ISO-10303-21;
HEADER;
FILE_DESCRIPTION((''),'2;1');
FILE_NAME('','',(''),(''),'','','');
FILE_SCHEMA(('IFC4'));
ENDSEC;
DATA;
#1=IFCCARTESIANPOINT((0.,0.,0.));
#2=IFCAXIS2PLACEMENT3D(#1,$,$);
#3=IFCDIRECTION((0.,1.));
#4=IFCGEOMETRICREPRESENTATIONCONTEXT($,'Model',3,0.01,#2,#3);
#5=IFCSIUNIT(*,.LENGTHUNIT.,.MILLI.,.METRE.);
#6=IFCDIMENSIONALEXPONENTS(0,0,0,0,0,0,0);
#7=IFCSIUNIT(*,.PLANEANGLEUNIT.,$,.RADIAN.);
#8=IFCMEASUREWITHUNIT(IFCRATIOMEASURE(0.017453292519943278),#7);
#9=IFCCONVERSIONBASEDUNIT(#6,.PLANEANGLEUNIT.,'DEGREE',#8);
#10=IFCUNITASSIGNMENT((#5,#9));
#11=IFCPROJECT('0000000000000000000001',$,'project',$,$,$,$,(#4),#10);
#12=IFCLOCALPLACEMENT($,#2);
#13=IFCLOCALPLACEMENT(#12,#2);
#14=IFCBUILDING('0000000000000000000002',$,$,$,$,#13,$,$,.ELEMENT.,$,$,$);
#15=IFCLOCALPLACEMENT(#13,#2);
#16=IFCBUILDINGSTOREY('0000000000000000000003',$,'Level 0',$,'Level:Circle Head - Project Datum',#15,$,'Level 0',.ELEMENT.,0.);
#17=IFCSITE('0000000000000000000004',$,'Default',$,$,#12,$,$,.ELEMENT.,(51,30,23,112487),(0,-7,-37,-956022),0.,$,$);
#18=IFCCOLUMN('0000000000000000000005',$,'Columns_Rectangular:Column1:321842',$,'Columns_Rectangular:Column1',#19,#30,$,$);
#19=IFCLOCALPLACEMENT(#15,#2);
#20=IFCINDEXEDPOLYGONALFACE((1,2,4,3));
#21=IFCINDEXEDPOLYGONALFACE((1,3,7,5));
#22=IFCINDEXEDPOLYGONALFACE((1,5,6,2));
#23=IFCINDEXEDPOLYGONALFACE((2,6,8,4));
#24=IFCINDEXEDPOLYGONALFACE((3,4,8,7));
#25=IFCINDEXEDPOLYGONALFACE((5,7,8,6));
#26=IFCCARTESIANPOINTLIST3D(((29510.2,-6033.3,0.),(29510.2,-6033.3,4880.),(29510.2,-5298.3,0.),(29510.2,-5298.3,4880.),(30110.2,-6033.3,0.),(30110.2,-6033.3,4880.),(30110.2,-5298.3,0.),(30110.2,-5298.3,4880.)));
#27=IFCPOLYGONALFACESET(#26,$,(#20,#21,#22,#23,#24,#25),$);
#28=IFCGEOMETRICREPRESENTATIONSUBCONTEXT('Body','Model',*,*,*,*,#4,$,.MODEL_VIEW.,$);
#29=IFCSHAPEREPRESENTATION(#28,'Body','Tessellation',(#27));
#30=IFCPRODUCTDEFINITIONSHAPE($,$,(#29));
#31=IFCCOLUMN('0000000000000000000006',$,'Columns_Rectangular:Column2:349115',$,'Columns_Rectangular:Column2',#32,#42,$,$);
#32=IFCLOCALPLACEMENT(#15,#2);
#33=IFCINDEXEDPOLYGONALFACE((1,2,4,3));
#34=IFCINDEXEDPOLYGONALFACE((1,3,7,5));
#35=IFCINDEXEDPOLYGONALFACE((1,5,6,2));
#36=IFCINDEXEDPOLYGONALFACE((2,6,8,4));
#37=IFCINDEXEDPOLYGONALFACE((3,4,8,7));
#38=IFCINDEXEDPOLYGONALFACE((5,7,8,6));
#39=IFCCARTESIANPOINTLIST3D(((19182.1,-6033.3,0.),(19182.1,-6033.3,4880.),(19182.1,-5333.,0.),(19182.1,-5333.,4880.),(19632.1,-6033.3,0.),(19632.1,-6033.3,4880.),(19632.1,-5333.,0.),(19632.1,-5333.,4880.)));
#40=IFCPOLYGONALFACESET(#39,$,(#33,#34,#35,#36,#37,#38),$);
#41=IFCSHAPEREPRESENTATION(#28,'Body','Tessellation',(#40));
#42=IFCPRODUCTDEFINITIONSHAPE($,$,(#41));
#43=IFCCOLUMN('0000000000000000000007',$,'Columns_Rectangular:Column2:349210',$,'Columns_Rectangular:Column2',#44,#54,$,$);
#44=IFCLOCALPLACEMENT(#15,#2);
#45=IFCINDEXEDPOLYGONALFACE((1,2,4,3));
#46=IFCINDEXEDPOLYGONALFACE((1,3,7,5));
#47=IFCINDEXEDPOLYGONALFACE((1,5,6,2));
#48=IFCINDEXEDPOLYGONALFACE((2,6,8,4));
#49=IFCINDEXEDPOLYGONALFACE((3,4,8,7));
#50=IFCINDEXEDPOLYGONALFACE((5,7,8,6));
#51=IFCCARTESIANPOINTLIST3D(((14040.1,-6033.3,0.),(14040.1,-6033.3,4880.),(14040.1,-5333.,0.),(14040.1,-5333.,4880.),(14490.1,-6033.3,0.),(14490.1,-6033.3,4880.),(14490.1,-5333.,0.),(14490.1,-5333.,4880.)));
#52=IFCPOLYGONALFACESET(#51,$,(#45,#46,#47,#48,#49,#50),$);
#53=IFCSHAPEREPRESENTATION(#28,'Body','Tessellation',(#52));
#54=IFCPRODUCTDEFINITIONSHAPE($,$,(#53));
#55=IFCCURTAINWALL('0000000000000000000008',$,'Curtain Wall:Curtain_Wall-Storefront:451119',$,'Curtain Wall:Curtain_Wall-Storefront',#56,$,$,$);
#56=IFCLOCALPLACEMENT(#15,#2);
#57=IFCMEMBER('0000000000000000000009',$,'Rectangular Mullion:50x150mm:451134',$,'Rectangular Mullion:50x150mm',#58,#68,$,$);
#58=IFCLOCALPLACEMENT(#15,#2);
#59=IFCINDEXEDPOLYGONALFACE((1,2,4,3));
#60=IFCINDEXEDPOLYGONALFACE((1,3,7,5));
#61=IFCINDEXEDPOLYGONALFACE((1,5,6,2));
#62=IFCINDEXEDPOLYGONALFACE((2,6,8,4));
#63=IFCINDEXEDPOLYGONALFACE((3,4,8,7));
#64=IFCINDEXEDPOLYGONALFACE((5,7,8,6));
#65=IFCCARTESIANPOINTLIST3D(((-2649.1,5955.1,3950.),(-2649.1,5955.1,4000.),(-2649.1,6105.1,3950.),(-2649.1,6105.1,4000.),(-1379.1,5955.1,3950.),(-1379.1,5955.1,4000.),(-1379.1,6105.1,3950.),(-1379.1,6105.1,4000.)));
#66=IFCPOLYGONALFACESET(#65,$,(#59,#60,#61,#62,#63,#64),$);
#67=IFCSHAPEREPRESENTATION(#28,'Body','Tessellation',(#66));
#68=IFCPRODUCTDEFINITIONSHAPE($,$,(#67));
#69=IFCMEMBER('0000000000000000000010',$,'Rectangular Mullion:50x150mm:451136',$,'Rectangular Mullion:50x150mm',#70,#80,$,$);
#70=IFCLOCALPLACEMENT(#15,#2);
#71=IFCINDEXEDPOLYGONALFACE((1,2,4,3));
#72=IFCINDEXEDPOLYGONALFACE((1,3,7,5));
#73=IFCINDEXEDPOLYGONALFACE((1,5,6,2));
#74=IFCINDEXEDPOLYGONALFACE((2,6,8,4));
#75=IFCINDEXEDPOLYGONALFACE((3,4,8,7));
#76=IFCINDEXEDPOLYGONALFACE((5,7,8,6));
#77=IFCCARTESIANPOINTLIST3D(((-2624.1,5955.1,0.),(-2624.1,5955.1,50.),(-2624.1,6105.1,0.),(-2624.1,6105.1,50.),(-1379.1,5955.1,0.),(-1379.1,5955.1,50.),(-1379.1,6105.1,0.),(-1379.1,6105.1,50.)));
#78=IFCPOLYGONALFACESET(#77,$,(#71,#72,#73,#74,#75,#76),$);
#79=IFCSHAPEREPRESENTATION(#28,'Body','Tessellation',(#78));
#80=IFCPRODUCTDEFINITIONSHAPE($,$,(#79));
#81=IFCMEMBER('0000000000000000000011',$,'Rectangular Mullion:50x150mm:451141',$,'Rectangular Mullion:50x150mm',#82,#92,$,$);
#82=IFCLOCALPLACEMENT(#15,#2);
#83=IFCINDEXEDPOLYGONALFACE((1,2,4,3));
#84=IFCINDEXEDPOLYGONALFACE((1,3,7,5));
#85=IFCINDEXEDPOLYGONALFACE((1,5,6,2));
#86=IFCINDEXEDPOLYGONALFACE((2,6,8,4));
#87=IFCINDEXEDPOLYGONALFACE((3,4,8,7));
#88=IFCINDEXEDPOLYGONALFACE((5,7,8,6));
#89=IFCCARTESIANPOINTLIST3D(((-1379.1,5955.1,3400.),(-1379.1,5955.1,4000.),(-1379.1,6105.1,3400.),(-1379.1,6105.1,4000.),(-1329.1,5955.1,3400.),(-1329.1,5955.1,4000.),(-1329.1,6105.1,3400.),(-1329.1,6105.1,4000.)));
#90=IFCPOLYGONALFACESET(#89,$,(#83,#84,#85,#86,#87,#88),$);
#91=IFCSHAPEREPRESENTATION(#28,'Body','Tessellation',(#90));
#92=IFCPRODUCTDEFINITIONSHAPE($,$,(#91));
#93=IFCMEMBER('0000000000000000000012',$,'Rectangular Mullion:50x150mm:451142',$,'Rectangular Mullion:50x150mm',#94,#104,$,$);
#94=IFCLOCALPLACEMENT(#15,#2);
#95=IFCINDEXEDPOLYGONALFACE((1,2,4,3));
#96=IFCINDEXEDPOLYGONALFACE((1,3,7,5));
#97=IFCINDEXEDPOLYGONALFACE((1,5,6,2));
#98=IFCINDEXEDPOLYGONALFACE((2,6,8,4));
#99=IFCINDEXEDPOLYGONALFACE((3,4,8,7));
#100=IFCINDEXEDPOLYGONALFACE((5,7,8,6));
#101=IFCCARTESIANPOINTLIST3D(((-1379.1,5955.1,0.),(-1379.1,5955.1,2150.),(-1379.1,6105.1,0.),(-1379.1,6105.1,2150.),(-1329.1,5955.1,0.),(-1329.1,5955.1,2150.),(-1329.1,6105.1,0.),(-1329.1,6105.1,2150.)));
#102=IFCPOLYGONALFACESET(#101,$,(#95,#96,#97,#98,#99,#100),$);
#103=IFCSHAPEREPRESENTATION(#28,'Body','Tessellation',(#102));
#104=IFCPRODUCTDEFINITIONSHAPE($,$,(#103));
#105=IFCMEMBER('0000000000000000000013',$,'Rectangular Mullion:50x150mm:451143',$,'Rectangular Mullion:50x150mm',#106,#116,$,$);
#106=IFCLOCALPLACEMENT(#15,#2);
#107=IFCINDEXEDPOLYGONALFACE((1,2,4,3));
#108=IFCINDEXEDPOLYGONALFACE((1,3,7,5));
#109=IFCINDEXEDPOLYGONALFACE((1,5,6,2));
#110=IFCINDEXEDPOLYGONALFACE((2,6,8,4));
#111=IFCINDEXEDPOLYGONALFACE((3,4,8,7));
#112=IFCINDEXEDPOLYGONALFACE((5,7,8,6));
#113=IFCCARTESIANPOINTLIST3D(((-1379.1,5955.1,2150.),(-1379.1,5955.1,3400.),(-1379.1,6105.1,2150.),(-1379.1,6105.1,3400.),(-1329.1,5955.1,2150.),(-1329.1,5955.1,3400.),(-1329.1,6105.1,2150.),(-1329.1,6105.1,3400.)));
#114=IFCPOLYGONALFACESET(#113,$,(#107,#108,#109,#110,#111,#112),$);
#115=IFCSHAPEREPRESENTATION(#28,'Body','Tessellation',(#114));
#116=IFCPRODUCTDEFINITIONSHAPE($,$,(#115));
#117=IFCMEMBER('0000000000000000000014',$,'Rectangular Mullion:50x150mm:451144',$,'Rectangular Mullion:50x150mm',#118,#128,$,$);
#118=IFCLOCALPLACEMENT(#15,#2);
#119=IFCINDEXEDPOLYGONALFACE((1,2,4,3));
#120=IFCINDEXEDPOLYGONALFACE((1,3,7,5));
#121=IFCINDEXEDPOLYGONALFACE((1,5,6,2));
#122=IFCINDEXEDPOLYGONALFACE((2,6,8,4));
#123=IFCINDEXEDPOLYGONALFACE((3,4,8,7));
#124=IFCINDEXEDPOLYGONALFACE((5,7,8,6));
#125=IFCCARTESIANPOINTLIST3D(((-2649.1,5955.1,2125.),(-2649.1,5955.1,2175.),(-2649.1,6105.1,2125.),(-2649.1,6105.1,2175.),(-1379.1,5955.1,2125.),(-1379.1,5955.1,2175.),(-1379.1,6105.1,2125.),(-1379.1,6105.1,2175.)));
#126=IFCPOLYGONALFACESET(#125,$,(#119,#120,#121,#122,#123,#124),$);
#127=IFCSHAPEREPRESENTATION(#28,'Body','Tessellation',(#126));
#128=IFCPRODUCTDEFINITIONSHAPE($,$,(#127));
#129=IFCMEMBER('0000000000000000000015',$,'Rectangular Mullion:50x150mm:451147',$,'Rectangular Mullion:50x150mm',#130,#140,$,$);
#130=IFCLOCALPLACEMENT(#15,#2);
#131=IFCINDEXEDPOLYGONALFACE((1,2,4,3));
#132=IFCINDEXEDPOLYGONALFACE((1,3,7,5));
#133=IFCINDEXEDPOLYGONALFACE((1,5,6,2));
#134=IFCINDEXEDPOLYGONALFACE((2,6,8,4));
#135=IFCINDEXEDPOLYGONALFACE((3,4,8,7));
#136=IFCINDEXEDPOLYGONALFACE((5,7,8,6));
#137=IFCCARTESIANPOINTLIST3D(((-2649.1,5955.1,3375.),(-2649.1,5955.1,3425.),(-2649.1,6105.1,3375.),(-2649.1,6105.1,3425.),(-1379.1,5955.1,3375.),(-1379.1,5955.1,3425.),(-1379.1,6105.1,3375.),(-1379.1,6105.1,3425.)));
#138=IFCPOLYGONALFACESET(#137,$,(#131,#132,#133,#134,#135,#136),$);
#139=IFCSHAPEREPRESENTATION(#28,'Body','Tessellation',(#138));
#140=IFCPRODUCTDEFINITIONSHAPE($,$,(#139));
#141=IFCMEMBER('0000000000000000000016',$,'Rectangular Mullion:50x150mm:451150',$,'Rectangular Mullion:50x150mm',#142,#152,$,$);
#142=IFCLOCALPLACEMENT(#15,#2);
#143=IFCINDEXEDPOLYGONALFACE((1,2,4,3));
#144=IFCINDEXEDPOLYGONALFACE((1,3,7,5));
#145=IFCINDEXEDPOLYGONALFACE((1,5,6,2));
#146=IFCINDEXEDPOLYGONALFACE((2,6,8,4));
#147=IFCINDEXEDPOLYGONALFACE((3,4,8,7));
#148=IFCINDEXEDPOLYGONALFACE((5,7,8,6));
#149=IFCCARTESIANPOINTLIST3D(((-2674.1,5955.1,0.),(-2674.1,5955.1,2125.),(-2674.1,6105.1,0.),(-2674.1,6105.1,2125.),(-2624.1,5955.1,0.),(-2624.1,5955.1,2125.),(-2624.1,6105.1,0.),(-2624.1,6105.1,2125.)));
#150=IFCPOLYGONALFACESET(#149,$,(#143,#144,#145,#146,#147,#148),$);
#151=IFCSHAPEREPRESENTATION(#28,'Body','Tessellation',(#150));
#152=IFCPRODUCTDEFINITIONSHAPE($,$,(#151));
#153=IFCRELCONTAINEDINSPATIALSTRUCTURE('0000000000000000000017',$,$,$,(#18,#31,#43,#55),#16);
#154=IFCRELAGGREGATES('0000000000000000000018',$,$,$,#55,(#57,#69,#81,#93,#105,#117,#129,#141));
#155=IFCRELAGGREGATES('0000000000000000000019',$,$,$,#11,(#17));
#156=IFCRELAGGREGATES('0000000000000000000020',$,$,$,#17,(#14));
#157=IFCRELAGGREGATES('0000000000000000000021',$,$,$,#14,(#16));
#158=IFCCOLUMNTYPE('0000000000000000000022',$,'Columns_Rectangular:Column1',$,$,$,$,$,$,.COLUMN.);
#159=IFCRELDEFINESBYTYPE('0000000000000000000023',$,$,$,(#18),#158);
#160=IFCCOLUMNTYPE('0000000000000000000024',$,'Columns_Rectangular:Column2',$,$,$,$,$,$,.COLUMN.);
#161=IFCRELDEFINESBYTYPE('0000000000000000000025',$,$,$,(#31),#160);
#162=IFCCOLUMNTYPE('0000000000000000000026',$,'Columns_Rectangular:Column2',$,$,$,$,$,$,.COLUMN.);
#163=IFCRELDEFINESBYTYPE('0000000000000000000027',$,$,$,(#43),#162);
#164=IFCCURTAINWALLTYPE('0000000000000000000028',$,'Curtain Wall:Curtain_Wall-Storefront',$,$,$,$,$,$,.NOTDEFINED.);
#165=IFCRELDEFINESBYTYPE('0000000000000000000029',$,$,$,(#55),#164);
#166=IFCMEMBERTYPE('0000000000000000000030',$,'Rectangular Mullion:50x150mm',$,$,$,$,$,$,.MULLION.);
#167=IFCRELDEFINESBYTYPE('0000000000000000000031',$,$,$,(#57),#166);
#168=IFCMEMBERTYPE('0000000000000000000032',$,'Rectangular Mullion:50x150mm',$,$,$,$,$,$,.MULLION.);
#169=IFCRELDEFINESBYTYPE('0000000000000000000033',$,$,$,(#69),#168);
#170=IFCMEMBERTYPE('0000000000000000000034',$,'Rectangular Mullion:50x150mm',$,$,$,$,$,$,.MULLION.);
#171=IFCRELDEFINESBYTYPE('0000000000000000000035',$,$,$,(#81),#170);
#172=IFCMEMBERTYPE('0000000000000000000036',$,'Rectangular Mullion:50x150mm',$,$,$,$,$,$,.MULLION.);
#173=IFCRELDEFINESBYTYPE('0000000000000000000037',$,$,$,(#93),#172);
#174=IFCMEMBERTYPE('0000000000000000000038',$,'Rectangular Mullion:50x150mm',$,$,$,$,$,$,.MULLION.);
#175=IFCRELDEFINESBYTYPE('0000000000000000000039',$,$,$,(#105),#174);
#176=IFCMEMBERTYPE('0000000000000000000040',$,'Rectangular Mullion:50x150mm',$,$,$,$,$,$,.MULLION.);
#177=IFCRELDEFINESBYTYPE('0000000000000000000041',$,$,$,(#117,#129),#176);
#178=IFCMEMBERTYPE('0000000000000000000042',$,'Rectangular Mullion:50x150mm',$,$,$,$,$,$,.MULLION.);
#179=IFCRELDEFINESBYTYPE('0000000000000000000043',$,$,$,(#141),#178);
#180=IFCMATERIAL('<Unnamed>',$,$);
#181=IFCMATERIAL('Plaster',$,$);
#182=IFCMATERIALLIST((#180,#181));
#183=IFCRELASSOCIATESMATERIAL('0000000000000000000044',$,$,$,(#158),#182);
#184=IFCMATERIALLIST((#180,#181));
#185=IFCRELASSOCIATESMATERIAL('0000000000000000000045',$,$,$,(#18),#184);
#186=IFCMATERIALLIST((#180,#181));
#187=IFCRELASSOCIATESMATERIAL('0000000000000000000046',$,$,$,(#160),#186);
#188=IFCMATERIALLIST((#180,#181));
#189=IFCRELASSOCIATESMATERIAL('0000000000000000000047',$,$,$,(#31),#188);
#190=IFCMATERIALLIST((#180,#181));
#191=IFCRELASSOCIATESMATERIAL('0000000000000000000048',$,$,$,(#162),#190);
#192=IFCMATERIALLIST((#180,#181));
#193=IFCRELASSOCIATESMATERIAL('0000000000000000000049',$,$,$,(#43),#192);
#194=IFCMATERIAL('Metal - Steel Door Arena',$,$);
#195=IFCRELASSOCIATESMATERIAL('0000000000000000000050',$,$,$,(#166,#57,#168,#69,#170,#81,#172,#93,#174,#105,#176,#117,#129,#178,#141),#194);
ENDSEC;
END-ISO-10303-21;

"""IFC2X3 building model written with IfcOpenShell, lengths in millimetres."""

from ifc_helpers import new_model, entity, si_unit, converted_unit, direction, frame, frame_2d, origin, origin_2d_with_axis, place, context, subcontext, project, spatial, rectangle, extrude, source, transform, mapped, material, material_list, type_object, type_shapes, element, aggregate, save


model = new_model("IFC2X3")

# Units and contexts
model_context = context("Model", 3, precision=0.01, world=origin(), true_north=direction((0.0, 1.0)))
body_context = subcontext(model_context, "Body", "Model", "MODEL_VIEW")
ifc_project = project(units=[si_unit("LENGTHUNIT", "METRE", prefix="MILLI"), converted_unit("PLANEANGLEUNIT", "DEGREE", entity("IfcRatioMeasure", 0.017453292519943278), si_unit("PLANEANGLEUNIT", "RADIAN"), dimensions=[0, 0, 0, 0, 0, 0, 0])], contexts=[model_context])

# Site, building, storey
site_placement = place(None, origin())
site = spatial("IfcSite", under=ifc_project, at=site_placement, Name="Default", CompositionType="ELEMENT", RefLatitude=(51, 30, 23, 112487), RefLongitude=(0, -7, -37, -956022), RefElevation=0.0)
building_placement = place(site_placement, origin())
building = spatial("IfcBuilding", under=site, at=building_placement, CompositionType="ELEMENT")
storey_placement = place(building_placement, origin())
storey = spatial("IfcBuildingStorey", under=building, at=storey_placement, Name="Level 0", ObjectType="Level:Circle Head - Project Datum", LongName="Level 0", CompositionType="ELEMENT", Elevation=0.0)

# Columns
ifc_material_1 = material(Name="<Unnamed>")
ifc_material_2 = material(Name="Plaster")
ifc_material_list_1 = material_list([ifc_material_1, ifc_material_2])
ifc_material_list_2 = material_list([ifc_material_1, ifc_material_2])
column_type_1 = type_object("IfcColumnType", Name="Columns_Rectangular:Column1", PredefinedType="COLUMN", material=ifc_material_list_2)
shared_shape_1 = source(origin(), body_context, "Body", "SweptSolid", [
    extrude(rectangle(XDim=735.0, YDim=600.0, at=frame_2d((0.0, 0.0), x_axis=(1.0, 0.0))), frame((29810.2, -5665.8, 0.0), z_axis=(0.0, 0.0, 1.0), x_axis=(0.0, -1.0, 0.0)), (0.0, 0.0, 1.0), 4880.0),
])
type_shapes(column_type_1, [shared_shape_1])
column_1_placement = place(storey_placement, origin())
element("IfcColumn", 1, at=column_1_placement, inside=storey, type_object=column_type_1, material=ifc_material_list_1, Name="Columns_Rectangular:Column1:321842", ObjectType="Columns_Rectangular:Column1", context=body_context, shape_type="MappedRepresentation", body=[
    mapped(shared_shape_1, transform((0.0, 0.0, 0.0), scale=1.0)),
])
ifc_material_list_3 = material_list([ifc_material_1, ifc_material_2])
ifc_material_list_4 = material_list([ifc_material_1, ifc_material_2])
column_type_2 = type_object("IfcColumnType", Name="Columns_Rectangular:Column2", PredefinedType="COLUMN", material=ifc_material_list_4)
shared_shape_2 = source(origin(), body_context, "Body", "SweptSolid", [
    extrude(rectangle(XDim=700.3, YDim=450.0, at=frame_2d((0.0, 0.0), x_axis=(1.0, 0.0))), frame((19407.1, -5683.1, 0.0), z_axis=(0.0, 0.0, 1.0), x_axis=(0.0, -1.0, 0.0)), (0.0, 0.0, 1.0), 4880.0),
])
type_shapes(column_type_2, [shared_shape_2])
column_2_placement = place(storey_placement, origin())
element("IfcColumn", 2, at=column_2_placement, inside=storey, type_object=column_type_2, material=ifc_material_list_3, Name="Columns_Rectangular:Column2:349115", ObjectType="Columns_Rectangular:Column2", context=body_context, shape_type="MappedRepresentation", body=[
    mapped(shared_shape_2, transform((0.0, 0.0, 0.0), scale=1.0)),
])
ifc_material_list_5 = material_list([ifc_material_1, ifc_material_2])
ifc_material_list_6 = material_list([ifc_material_1, ifc_material_2])
column_type_3 = type_object("IfcColumnType", Name="Columns_Rectangular:Column2", PredefinedType="COLUMN", material=ifc_material_list_6)
shared_shape_3 = source(origin(), body_context, "Body", "SweptSolid", [
    extrude(rectangle(XDim=700.3, YDim=450.0, at=frame_2d((0.0, 0.0), x_axis=(1.0, 0.0))), frame((14265.1, -5683.1, 0.0), z_axis=(0.0, 0.0, 1.0), x_axis=(0.0, -1.0, 0.0)), (0.0, 0.0, 1.0), 4880.0),
])
type_shapes(column_type_3, [shared_shape_3])
column_3_placement = place(storey_placement, origin())
element("IfcColumn", 3, at=column_3_placement, inside=storey, type_object=column_type_3, material=ifc_material_list_5, Name="Columns_Rectangular:Column2:349210", ObjectType="Columns_Rectangular:Column2", context=body_context, shape_type="MappedRepresentation", body=[
    mapped(shared_shape_3, transform((0.0, 0.0, 0.0), scale=1.0)),
])

# Curtain wall, members
curtain_wall_type = type_object("IfcCurtainWallType", Name="Curtain Wall:Curtain_Wall-Storefront", PredefinedType="NOTDEFINED")
curtain_wall_placement = place(storey_placement, origin())
curtain_wall = element("IfcCurtainWall", 4, at=curtain_wall_placement, inside=storey, type_object=curtain_wall_type, Name="Curtain Wall:Curtain_Wall-Storefront:451119", ObjectType="Curtain Wall:Curtain_Wall-Storefront")
ifc_material_3 = material(Name="Metal - Steel Door Arena")
member_type_1 = type_object("IfcMemberType", Name="Rectangular Mullion:50x150mm", PredefinedType="MULLION", material=ifc_material_3)
shared_shape_4 = source(origin(), body_context, "Body", "SweptSolid", [
    extrude(rectangle(XDim=150.0, YDim=50.0, at=origin_2d_with_axis()), frame((-25.0, 0.0, -1270.0), z_axis=(0.0, 0.0, 1.0), x_axis=(0.0, -1.0, 0.0)), (0.0, 0.0, 1.0), 1270.0),
])
type_shapes(member_type_1, [shared_shape_4])
member_1_placement = place(curtain_wall_placement, frame((-2649.1, 6030.1, 4000.0), z_axis=(-1.0, 0.0, 0.0), x_axis=(0.0, 0.0, 1.0)))
member_1 = element("IfcMember", 5, at=member_1_placement, type_object=member_type_1, material=ifc_material_3, Name="Rectangular Mullion:50x150mm:451134", ObjectType="Rectangular Mullion:50x150mm", context=body_context, shape_type="MappedRepresentation", body=[
    mapped(shared_shape_4, transform((0.0, 0.0, 0.0), scale=1.0)),
])
member_type_2 = type_object("IfcMemberType", Name="Rectangular Mullion:50x150mm", PredefinedType="MULLION", material=ifc_material_3)
shared_shape_5 = source(origin(), body_context, "Body", "SweptSolid", [
    extrude(rectangle(XDim=150.0, YDim=50.0, at=origin_2d_with_axis()), frame((-25.0, 0.0, -1245.0), z_axis=(0.0, 0.0, 1.0), x_axis=(0.0, -1.0, 0.0)), (0.0, 0.0, 1.0), 1245.0),
])
type_shapes(member_type_2, [shared_shape_5])
member_2_placement = place(curtain_wall_placement, frame((-1379.1, 6030.1, 0.0), z_axis=(1.0, 0.0, 0.0), x_axis=(0.0, 0.0, -1.0)))
member_2 = element("IfcMember", 6, at=member_2_placement, type_object=member_type_2, material=ifc_material_3, Name="Rectangular Mullion:50x150mm:451136", ObjectType="Rectangular Mullion:50x150mm", context=body_context, shape_type="MappedRepresentation", body=[
    mapped(shared_shape_5, transform((0.0, 0.0, 0.0), scale=1.0)),
])
member_type_3 = type_object("IfcMemberType", Name="Rectangular Mullion:50x150mm", PredefinedType="MULLION", material=ifc_material_3)
shared_shape_6 = source(origin(), body_context, "Body", "SweptSolid", [
    extrude(rectangle(XDim=150.0, YDim=50.0, at=origin_2d_with_axis()), frame((-25.0, 0.0, -600.0), z_axis=(0.0, 0.0, 1.0), x_axis=(0.0, -1.0, 0.0)), (0.0, 0.0, 1.0), 600.0),
])
type_shapes(member_type_3, [shared_shape_6])
member_3_placement = place(curtain_wall_placement, frame((-1329.1, 6030.1, 4000.0)))
member_3 = element("IfcMember", 7, at=member_3_placement, type_object=member_type_3, material=ifc_material_3, Name="Rectangular Mullion:50x150mm:451141", ObjectType="Rectangular Mullion:50x150mm", context=body_context, shape_type="MappedRepresentation", body=[
    mapped(shared_shape_6, transform((0.0, 0.0, 0.0), scale=1.0)),
])
member_type_4 = type_object("IfcMemberType", Name="Rectangular Mullion:50x150mm", PredefinedType="MULLION", material=ifc_material_3)
shared_shape_7 = source(origin(), body_context, "Body", "SweptSolid", [
    extrude(rectangle(XDim=150.0, YDim=50.0, at=origin_2d_with_axis()), frame((-25.0, 0.0, -2150.0), z_axis=(0.0, 0.0, 1.0), x_axis=(0.0, -1.0, 0.0)), (0.0, 0.0, 1.0), 2150.0),
])
type_shapes(member_type_4, [shared_shape_7])
member_4_placement = place(curtain_wall_placement, frame((-1329.1, 6030.1, 2150.0)))
member_4 = element("IfcMember", 8, at=member_4_placement, type_object=member_type_4, material=ifc_material_3, Name="Rectangular Mullion:50x150mm:451142", ObjectType="Rectangular Mullion:50x150mm", context=body_context, shape_type="MappedRepresentation", body=[
    mapped(shared_shape_7, transform((0.0, 0.0, 0.0), scale=1.0)),
])
member_type_5 = type_object("IfcMemberType", Name="Rectangular Mullion:50x150mm", PredefinedType="MULLION", material=ifc_material_3)
shared_shape_8 = source(origin(), body_context, "Body", "SweptSolid", [
    extrude(rectangle(XDim=150.0, YDim=50.0, at=origin_2d_with_axis()), frame((-25.0, 0.0, -1250.0), z_axis=(0.0, 0.0, 1.0), x_axis=(0.0, -1.0, 0.0)), (0.0, 0.0, 1.0), 1250.0),
])
type_shapes(member_type_5, [shared_shape_8])
member_5_placement = place(curtain_wall_placement, frame((-1329.1, 6030.1, 3400.0)))
member_5 = element("IfcMember", 9, at=member_5_placement, type_object=member_type_5, material=ifc_material_3, Name="Rectangular Mullion:50x150mm:451143", ObjectType="Rectangular Mullion:50x150mm", context=body_context, shape_type="MappedRepresentation", body=[
    mapped(shared_shape_8, transform((0.0, 0.0, 0.0), scale=1.0)),
])
member_type_6 = type_object("IfcMemberType", Name="Rectangular Mullion:50x150mm", PredefinedType="MULLION", material=ifc_material_3)
shared_shape_9 = source(origin(), body_context, "Body", "SweptSolid", [
    extrude(rectangle(XDim=150.0, YDim=50.0, at=origin_2d_with_axis()), frame((0.0, 0.0, -1270.0), z_axis=(0.0, 0.0, 1.0), x_axis=(0.0, -1.0, 0.0)), (0.0, 0.0, 1.0), 1270.0),
])
type_shapes(member_type_6, [shared_shape_9])
member_6_placement = place(curtain_wall_placement, frame((-2649.1, 6030.1, 2150.0), z_axis=(-1.0, 0.0, 0.0), x_axis=(0.0, 0.0, 1.0)))
member_6 = element("IfcMember", 10, at=member_6_placement, type_object=member_type_6, material=ifc_material_3, Name="Rectangular Mullion:50x150mm:451144", ObjectType="Rectangular Mullion:50x150mm", context=body_context, shape_type="MappedRepresentation", body=[
    mapped(shared_shape_9, transform((0.0, 0.0, 0.0), scale=1.0)),
])
member_7_placement = place(curtain_wall_placement, frame((-2649.1, 6030.1, 3400.0), z_axis=(-1.0, 0.0, 0.0), x_axis=(0.0, 0.0, 1.0)))
member_7 = element("IfcMember", 11, at=member_7_placement, type_object=member_type_6, material=ifc_material_3, Name="Rectangular Mullion:50x150mm:451147", ObjectType="Rectangular Mullion:50x150mm", context=body_context, shape_type="MappedRepresentation", body=[
    mapped(shared_shape_9, transform((0.0, 0.0, 0.0), scale=1.0)),
])
member_type_7 = type_object("IfcMemberType", Name="Rectangular Mullion:50x150mm", PredefinedType="MULLION", material=ifc_material_3)
shared_shape_10 = source(origin(), body_context, "Body", "SweptSolid", [
    extrude(rectangle(XDim=150.0, YDim=50.0, at=origin_2d_with_axis()), frame((0.0, 0.0, -2125.0), z_axis=(0.0, 0.0, 1.0), x_axis=(0.0, -1.0, 0.0)), (0.0, 0.0, 1.0), 2125.0),
])
type_shapes(member_type_7, [shared_shape_10])
member_8_placement = place(curtain_wall_placement, frame((-2649.1, 6030.1, 0.0), z_axis=(0.0, 0.0, -1.0), x_axis=(-1.0, 0.0, 0.0)))
member_8 = element("IfcMember", 12, at=member_8_placement, type_object=member_type_7, material=ifc_material_3, Name="Rectangular Mullion:50x150mm:451150", ObjectType="Rectangular Mullion:50x150mm", context=body_context, shape_type="MappedRepresentation", body=[
    mapped(shared_shape_10, transform((0.0, 0.0, 0.0), scale=1.0)),
])

aggregate(curtain_wall, [member_1, member_2, member_3, member_4, member_5, member_6, member_7, member_8])

save(model, "model.ifc")
